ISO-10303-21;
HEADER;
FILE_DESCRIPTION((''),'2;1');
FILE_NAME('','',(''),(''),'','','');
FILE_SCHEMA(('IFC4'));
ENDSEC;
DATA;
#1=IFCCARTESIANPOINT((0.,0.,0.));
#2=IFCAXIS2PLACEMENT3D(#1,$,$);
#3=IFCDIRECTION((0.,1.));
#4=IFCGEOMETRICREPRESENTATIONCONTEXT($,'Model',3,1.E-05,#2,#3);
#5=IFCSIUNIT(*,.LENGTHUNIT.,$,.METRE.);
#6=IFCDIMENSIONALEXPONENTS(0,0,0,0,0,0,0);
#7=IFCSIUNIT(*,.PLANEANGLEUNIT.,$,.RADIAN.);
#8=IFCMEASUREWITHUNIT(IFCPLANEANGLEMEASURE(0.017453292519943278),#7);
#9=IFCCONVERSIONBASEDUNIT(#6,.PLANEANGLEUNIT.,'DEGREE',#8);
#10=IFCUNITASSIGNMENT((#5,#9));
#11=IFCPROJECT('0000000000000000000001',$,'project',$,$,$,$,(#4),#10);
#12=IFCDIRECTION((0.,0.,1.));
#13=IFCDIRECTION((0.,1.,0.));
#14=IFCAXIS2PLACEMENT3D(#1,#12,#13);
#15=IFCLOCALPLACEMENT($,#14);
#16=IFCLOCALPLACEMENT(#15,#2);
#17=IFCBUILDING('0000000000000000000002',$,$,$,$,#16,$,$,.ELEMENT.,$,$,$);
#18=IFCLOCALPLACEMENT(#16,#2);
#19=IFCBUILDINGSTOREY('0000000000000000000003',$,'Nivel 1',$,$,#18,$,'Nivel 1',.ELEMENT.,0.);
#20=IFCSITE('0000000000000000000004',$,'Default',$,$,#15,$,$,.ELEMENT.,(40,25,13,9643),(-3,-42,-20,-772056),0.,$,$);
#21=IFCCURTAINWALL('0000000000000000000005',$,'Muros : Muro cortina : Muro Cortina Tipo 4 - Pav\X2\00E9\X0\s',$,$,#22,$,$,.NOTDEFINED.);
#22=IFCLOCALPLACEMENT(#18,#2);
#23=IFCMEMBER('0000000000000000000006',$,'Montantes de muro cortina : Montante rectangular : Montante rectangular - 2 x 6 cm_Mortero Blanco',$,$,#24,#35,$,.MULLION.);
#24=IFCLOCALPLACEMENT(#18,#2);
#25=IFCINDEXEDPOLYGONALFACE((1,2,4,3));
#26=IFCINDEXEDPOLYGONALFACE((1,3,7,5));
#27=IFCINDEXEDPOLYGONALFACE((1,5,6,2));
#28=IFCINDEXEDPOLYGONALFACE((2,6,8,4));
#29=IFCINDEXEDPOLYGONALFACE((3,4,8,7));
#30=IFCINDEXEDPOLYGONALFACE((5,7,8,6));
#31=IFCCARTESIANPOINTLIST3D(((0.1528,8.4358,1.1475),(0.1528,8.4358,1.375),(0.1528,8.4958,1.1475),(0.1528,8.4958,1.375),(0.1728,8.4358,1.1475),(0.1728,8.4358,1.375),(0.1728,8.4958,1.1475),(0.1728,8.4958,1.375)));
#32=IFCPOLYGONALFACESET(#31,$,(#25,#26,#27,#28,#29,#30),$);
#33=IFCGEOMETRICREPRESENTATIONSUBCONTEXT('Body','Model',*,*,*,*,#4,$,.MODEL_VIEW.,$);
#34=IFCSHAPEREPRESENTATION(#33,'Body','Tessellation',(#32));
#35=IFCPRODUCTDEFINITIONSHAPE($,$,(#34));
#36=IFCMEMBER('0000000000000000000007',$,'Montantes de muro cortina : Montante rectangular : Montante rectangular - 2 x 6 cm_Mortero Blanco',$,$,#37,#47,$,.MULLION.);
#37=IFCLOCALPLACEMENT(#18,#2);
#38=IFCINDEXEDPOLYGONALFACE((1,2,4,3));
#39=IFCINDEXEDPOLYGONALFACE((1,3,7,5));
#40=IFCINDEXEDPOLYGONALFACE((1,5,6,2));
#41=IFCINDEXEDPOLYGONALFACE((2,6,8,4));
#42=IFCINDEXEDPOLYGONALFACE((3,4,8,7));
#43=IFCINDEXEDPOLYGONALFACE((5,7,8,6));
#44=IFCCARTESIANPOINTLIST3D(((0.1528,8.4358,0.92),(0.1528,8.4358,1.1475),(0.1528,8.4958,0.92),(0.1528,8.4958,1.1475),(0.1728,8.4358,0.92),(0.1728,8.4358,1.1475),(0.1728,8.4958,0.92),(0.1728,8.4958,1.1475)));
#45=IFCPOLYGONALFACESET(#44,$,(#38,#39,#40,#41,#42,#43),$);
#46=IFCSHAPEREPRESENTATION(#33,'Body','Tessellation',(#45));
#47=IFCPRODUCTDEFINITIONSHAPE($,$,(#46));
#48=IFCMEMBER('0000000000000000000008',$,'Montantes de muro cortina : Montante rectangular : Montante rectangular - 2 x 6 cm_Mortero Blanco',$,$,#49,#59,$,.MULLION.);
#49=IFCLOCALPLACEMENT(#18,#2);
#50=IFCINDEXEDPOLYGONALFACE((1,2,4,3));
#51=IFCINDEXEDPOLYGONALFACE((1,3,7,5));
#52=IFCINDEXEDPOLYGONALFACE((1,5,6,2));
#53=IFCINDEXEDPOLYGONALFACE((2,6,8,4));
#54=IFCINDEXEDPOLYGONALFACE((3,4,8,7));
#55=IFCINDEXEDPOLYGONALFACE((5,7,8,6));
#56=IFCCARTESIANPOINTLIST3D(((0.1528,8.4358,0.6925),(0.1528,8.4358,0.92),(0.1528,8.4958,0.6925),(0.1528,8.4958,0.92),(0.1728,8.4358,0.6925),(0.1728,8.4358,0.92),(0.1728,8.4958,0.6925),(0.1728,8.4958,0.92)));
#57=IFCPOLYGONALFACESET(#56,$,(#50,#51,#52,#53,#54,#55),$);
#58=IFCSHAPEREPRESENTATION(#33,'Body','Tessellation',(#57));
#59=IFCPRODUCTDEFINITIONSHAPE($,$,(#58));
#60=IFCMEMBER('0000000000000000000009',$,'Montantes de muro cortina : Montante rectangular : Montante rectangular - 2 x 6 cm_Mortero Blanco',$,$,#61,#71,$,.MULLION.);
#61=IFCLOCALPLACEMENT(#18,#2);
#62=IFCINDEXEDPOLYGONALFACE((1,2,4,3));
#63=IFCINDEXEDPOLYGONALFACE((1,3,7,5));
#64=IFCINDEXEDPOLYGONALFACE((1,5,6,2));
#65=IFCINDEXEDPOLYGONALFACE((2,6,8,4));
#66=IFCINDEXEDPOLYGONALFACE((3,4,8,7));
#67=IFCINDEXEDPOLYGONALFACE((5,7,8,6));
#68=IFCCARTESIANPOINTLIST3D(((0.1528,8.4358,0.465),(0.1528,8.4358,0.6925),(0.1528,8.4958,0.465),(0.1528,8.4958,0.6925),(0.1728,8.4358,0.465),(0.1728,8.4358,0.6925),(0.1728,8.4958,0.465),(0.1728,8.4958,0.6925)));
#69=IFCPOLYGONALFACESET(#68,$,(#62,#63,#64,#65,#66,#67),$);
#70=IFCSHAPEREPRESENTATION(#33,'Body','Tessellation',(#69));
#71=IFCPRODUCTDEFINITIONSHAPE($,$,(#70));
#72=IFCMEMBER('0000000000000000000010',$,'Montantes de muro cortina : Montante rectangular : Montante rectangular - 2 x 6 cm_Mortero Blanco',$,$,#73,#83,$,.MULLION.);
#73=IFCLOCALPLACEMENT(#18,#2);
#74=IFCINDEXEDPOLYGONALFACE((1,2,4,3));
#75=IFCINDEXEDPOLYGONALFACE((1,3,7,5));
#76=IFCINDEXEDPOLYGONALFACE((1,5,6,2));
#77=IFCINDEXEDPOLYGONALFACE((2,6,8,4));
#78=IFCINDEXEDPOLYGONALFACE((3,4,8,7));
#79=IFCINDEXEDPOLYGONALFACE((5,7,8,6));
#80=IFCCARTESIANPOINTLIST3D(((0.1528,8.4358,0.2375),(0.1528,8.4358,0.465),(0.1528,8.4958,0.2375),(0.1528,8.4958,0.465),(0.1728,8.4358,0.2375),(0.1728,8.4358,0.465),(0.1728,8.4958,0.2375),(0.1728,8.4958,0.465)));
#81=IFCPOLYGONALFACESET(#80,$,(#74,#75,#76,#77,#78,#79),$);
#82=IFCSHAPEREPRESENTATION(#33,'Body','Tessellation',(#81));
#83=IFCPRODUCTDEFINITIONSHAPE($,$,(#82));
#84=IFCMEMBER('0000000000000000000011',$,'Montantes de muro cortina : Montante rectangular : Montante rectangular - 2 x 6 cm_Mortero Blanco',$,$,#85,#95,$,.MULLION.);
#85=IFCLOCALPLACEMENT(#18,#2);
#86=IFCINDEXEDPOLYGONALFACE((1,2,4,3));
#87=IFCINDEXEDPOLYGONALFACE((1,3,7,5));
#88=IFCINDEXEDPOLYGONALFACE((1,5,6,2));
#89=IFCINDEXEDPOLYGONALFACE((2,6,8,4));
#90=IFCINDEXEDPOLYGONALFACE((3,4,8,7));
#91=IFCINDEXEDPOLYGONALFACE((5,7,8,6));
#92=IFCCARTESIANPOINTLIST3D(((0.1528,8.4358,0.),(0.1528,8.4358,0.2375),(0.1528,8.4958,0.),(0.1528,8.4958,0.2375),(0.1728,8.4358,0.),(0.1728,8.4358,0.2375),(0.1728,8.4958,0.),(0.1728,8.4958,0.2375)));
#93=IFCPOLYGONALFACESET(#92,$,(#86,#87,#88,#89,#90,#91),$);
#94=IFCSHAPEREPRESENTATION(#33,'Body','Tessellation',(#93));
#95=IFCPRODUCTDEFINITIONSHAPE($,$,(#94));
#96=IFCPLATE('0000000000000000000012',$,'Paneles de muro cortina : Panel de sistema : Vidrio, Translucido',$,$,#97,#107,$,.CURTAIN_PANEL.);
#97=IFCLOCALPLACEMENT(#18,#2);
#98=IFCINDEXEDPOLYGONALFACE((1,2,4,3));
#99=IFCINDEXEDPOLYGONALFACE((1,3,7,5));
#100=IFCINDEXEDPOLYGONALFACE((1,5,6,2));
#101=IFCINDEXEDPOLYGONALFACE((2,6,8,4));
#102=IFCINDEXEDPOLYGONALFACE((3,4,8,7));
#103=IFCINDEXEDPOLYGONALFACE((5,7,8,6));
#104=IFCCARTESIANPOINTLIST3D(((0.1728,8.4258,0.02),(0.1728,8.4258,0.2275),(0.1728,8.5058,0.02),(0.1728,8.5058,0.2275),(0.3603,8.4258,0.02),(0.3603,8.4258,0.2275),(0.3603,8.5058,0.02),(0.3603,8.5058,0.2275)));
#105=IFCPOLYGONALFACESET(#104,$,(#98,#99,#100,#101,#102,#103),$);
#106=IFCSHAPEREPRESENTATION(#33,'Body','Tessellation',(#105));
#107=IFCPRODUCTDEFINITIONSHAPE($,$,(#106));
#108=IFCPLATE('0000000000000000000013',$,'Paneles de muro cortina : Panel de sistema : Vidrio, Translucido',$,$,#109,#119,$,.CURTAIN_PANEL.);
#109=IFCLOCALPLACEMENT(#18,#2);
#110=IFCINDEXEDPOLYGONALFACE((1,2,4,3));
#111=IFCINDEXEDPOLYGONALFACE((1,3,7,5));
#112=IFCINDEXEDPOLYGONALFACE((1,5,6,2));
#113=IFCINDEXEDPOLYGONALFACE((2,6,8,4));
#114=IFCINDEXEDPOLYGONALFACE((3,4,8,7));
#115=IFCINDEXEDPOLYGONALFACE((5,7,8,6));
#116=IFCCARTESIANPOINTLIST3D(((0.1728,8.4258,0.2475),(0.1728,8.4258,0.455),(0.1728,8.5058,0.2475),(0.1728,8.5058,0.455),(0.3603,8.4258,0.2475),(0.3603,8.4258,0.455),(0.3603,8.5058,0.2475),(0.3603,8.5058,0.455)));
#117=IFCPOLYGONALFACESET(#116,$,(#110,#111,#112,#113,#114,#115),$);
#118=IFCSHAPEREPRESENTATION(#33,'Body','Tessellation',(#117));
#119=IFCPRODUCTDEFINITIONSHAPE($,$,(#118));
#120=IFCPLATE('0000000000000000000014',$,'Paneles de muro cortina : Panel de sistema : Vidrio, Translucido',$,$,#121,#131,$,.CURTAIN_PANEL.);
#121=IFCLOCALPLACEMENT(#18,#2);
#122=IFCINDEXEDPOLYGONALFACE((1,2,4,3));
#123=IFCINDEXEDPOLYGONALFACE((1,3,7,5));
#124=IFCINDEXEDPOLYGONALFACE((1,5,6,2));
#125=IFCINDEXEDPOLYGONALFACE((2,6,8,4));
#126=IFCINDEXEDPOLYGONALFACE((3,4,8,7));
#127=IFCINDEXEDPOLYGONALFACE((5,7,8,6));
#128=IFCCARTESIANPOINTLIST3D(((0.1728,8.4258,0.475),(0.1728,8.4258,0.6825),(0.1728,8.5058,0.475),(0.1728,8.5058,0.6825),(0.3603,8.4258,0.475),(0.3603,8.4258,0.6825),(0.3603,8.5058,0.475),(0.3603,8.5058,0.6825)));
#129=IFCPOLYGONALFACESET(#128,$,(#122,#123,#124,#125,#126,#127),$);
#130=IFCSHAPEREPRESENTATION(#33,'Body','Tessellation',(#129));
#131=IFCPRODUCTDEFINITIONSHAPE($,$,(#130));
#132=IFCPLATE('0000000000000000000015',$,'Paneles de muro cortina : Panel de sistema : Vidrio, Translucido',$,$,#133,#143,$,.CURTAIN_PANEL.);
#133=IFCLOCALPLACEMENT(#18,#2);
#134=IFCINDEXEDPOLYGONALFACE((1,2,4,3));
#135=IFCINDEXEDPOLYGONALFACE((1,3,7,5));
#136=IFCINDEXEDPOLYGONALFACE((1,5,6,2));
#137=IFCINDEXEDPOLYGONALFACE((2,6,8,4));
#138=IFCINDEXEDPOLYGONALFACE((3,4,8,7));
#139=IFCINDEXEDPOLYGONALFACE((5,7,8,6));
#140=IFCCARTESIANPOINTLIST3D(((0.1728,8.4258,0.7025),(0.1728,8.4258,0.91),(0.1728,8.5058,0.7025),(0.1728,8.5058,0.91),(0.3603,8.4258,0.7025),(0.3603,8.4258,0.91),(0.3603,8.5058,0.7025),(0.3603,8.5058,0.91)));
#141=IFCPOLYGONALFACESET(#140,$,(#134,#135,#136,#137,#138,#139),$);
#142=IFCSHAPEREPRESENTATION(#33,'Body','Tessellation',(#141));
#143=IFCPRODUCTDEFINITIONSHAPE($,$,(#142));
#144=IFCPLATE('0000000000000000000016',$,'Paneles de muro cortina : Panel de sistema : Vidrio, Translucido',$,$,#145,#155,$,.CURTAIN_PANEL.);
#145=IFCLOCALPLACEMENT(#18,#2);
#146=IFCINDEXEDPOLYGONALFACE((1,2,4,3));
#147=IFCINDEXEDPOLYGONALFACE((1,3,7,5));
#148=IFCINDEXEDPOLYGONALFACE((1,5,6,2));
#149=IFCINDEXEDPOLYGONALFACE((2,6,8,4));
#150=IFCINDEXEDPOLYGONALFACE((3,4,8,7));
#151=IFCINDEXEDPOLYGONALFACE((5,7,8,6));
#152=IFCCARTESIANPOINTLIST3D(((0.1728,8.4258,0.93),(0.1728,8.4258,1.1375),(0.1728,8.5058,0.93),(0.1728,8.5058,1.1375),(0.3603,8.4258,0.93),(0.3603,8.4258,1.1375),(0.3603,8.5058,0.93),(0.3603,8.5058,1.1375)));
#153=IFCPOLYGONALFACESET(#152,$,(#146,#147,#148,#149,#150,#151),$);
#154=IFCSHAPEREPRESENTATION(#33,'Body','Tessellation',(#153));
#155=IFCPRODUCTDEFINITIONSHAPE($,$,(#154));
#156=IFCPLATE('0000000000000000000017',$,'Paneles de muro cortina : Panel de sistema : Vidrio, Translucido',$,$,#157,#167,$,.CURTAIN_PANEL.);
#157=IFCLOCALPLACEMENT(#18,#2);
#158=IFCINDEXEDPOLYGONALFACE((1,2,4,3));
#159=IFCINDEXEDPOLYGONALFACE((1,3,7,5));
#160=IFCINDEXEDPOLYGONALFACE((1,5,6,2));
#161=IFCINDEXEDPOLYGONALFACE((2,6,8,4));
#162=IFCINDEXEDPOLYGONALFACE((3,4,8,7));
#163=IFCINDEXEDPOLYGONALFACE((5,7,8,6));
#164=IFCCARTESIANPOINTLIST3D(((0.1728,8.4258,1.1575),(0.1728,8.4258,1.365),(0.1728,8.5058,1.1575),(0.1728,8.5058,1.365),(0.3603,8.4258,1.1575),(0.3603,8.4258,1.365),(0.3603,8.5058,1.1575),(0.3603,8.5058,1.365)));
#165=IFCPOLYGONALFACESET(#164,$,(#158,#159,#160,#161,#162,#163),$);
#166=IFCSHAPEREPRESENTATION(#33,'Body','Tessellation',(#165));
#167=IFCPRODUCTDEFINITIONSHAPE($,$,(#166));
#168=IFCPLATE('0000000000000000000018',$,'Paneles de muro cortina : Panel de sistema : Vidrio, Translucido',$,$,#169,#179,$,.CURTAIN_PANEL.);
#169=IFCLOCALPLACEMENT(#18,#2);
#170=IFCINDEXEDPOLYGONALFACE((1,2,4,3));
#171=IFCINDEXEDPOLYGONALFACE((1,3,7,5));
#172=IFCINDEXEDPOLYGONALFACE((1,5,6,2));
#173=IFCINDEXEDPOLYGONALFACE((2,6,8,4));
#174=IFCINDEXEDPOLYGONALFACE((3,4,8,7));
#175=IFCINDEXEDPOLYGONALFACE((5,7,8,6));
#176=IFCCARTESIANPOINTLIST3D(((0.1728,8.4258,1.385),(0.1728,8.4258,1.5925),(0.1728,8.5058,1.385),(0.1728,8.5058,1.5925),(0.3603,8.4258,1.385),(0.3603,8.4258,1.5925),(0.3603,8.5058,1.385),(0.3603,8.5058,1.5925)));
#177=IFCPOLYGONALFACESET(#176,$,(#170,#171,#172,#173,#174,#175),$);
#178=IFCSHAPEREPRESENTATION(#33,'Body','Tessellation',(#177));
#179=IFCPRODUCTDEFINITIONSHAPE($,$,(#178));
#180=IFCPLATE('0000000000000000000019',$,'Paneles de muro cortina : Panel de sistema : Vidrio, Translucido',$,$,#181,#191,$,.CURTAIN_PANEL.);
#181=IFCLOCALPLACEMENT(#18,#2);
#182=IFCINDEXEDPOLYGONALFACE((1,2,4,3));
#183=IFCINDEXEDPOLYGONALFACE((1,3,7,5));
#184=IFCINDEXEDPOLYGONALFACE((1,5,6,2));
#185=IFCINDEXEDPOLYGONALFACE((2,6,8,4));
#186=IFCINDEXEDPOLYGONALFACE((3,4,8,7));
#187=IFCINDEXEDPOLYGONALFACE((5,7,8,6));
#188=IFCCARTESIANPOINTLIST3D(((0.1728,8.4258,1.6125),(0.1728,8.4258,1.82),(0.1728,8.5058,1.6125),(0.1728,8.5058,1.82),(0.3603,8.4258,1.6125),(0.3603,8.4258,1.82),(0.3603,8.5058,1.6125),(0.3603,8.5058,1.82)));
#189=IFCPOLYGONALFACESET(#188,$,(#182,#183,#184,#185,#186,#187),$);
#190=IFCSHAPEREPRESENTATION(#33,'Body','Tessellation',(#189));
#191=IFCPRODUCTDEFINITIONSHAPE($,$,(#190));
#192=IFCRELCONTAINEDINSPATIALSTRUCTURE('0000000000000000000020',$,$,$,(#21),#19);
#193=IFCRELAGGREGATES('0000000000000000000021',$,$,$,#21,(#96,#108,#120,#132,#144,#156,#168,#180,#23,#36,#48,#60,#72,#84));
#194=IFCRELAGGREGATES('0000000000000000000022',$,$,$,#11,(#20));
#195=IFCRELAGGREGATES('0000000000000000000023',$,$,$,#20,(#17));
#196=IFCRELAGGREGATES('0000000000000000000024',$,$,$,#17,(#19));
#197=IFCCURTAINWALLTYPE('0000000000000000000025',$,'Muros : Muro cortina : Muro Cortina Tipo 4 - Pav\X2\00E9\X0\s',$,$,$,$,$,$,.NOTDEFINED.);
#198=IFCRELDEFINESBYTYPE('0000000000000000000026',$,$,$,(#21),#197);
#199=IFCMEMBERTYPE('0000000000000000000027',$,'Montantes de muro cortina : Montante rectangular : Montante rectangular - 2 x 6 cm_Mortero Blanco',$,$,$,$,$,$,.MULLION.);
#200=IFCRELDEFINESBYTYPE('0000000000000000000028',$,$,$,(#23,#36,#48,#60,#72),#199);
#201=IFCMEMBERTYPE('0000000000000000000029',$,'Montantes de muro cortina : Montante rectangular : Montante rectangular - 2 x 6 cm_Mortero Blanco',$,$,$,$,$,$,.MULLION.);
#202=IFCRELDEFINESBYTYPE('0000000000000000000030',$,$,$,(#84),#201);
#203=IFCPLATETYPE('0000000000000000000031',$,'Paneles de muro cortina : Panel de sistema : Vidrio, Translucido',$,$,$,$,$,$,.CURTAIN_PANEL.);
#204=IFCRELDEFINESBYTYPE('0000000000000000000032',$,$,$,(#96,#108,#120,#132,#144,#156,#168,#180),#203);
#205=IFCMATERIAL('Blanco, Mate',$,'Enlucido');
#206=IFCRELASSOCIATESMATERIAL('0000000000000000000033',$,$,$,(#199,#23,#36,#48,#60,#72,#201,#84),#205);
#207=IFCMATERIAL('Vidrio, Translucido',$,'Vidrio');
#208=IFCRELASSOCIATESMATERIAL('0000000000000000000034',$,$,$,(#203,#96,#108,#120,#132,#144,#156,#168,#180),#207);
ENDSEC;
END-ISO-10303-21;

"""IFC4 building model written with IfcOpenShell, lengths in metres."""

from ifc_helpers import new_model, entity, si_unit, converted_unit, direction, frame, origin, place, context, subcontext, project, spatial, indexed_curve, outline, extrude, source, transform, mapped, material, type_object, type_shapes, element, aggregate, save


model = new_model("IFC4")

# Units and contexts
model_context = context("Model", 3, precision=1e-05, world=origin(), true_north=direction((0.0, 1.0)))
body_context = subcontext(model_context, "Body", "Model", "MODEL_VIEW")
ifc_project = project(units=[si_unit("LENGTHUNIT", "METRE"), converted_unit("PLANEANGLEUNIT", "DEGREE", entity("IfcPlaneAngleMeasure", 0.017453292519943278), si_unit("PLANEANGLEUNIT", "RADIAN"), dimensions=[0, 0, 0, 0, 0, 0, 0])], contexts=[model_context])

# Site, building, storey
site_placement = place(None, frame((0.0, 0.0, 0.0), z_axis=(0.0, 0.0, 1.0), x_axis=(0.0, 1.0, 0.0)))
site = spatial("IfcSite", under=ifc_project, at=site_placement, Name="Default", CompositionType="ELEMENT", RefLatitude=(40, 25, 13, 9643), RefLongitude=(-3, -42, -20, -772056), RefElevation=0.0)
building_placement = place(site_placement, origin())
building = spatial("IfcBuilding", under=site, at=building_placement, CompositionType="ELEMENT")
storey_placement = place(building_placement, origin())
storey = spatial("IfcBuildingStorey", under=building, at=storey_placement, Name="Nivel 1", LongName="Nivel 1", CompositionType="ELEMENT", Elevation=0.0)

# Curtain wall, members, plates
curtain_wall_type = type_object("IfcCurtainWallType", Name="Muros : Muro cortina : Muro Cortina Tipo 4 - Pavés", PredefinedType="NOTDEFINED")
curtain_wall_placement = place(storey_placement, origin())
curtain_wall = element("IfcCurtainWall", 1, at=curtain_wall_placement, inside=storey, type_object=curtain_wall_type, Name="Muros : Muro cortina : Muro Cortina Tipo 4 - Pavés", PredefinedType="NOTDEFINED")
ifc_material_1 = material(Name="Blanco, Mate", Category="Enlucido")
member_type_1 = type_object("IfcMemberType", Name="Montantes de muro cortina : Montante rectangular : Montante rectangular - 2 x 6 cm_Mortero Blanco", PredefinedType="MULLION", material=ifc_material_1)
shared_shape_1 = source(origin(), body_context, "Body", "SweptSolid", [
    extrude(outline(indexed_curve([(-0.01, -0.03), (0.01, -0.03), (0.01, 0.03), (-0.01, 0.03), (-0.01, -0.03)], self_intersect=False)), frame((-0.01, 0.0, -0.2275), z_axis=(0.0, 0.0, 1.0), x_axis=(-1.0, 0.0, 0.0)), (0.0, 0.0, 1.0), 0.2275),
])
type_shapes(member_type_1, [shared_shape_1])
member_1_placement = place(curtain_wall_placement, frame((0.1528, 8.4658, 1.1475), z_axis=(0.0, 0.0, -1.0), x_axis=(-1.0, 0.0, 0.0)))
member_1 = element("IfcMember", 2, at=member_1_placement, type_object=member_type_1, material=ifc_material_1, Name="Montantes de muro cortina : Montante rectangular : Montante rectangular - 2 x 6 cm_Mortero Blanco", PredefinedType="MULLION", context=body_context, shape_type="MappedRepresentation", body=[
    mapped(shared_shape_1, transform((0.0, 0.0, 0.0), scale=1.0)),
])
member_2_placement = place(curtain_wall_placement, frame((0.1528, 8.4658, 0.92), z_axis=(0.0, 0.0, -1.0), x_axis=(-1.0, 0.0, 0.0)))
member_2 = element("IfcMember", 3, at=member_2_placement, type_object=member_type_1, material=ifc_material_1, Name="Montantes de muro cortina : Montante rectangular : Montante rectangular - 2 x 6 cm_Mortero Blanco", PredefinedType="MULLION", context=body_context, shape_type="MappedRepresentation", body=[
    mapped(shared_shape_1, transform((0.0, 0.0, 0.0), scale=1.0)),
])
member_3_placement = place(curtain_wall_placement, frame((0.1528, 8.4658, 0.6925), z_axis=(0.0, 0.0, -1.0), x_axis=(-1.0, 0.0, 0.0)))
member_3 = element("IfcMember", 4, at=member_3_placement, type_object=member_type_1, material=ifc_material_1, Name="Montantes de muro cortina : Montante rectangular : Montante rectangular - 2 x 6 cm_Mortero Blanco", PredefinedType="MULLION", context=body_context, shape_type="MappedRepresentation", body=[
    mapped(shared_shape_1, transform((0.0, 0.0, 0.0), scale=1.0)),
])
member_4_placement = place(curtain_wall_placement, frame((0.1528, 8.4658, 0.465), z_axis=(0.0, 0.0, -1.0), x_axis=(-1.0, 0.0, 0.0)))
member_4 = element("IfcMember", 5, at=member_4_placement, type_object=member_type_1, material=ifc_material_1, Name="Montantes de muro cortina : Montante rectangular : Montante rectangular - 2 x 6 cm_Mortero Blanco", PredefinedType="MULLION", context=body_context, shape_type="MappedRepresentation", body=[
    mapped(shared_shape_1, transform((0.0, 0.0, 0.0), scale=1.0)),
])
member_5_placement = place(curtain_wall_placement, frame((0.1528, 8.4658, 0.2375), z_axis=(0.0, 0.0, -1.0), x_axis=(-1.0, 0.0, 0.0)))
member_5 = element("IfcMember", 6, at=member_5_placement, type_object=member_type_1, material=ifc_material_1, Name="Montantes de muro cortina : Montante rectangular : Montante rectangular - 2 x 6 cm_Mortero Blanco", PredefinedType="MULLION", context=body_context, shape_type="MappedRepresentation", body=[
    mapped(shared_shape_1, transform((0.0, 0.0, 0.0), scale=1.0)),
])
member_type_2 = type_object("IfcMemberType", Name="Montantes de muro cortina : Montante rectangular : Montante rectangular - 2 x 6 cm_Mortero Blanco", PredefinedType="MULLION", material=ifc_material_1)
shared_shape_2 = source(origin(), body_context, "Body", "SweptSolid", [
    extrude(outline(indexed_curve([(-0.01, -0.03), (0.01, -0.03), (0.01, 0.03), (-0.01, 0.03), (-0.01, -0.03)], self_intersect=False)), frame((-0.01, 0.0, -0.2375), z_axis=(0.0, 0.0, 1.0), x_axis=(-1.0, 0.0, 0.0)), (0.0, 0.0, 1.0), 0.2375),
])
type_shapes(member_type_2, [shared_shape_2])
member_6_placement = place(curtain_wall_placement, frame((0.1528, 8.4658, 0.0), z_axis=(0.0, 0.0, -1.0), x_axis=(-1.0, 0.0, 0.0)))
member_6 = element("IfcMember", 7, at=member_6_placement, type_object=member_type_2, material=ifc_material_1, Name="Montantes de muro cortina : Montante rectangular : Montante rectangular - 2 x 6 cm_Mortero Blanco", PredefinedType="MULLION", context=body_context, shape_type="MappedRepresentation", body=[
    mapped(shared_shape_2, transform((0.0, 0.0, 0.0), scale=1.0)),
])
ifc_material_2 = material(Name="Vidrio, Translucido", Category="Vidrio")
plate_type = type_object("IfcPlateType", Name="Paneles de muro cortina : Panel de sistema : Vidrio, Translucido", PredefinedType="CURTAIN_PANEL", material=ifc_material_2)
shared_shape_3 = source(origin(), body_context, "Body", "SweptSolid", [
    extrude(outline(indexed_curve([(-0.04, -0.0938), (0.04, -0.0938), (0.04, 0.0938), (-0.04, 0.0938), (-0.04, -0.0938)], self_intersect=False)), frame((0.0, 0.0, 0.0), z_axis=(0.0, 0.0, 1.0), x_axis=(0.0, 1.0, 0.0)), (0.0, 0.0, 1.0), 0.2075),
])
type_shapes(plate_type, [shared_shape_3])
plate_1_placement = place(curtain_wall_placement, frame((0.2665, 8.4658, 0.02), z_axis=(0.0, 0.0, 1.0), x_axis=(-1.0, 0.0, 0.0)))
plate_1 = element("IfcPlate", 8, at=plate_1_placement, type_object=plate_type, material=ifc_material_2, Name="Paneles de muro cortina : Panel de sistema : Vidrio, Translucido", PredefinedType="CURTAIN_PANEL", context=body_context, shape_type="MappedRepresentation", body=[
    mapped(shared_shape_3, transform((0.0, 0.0, 0.0), scale=1.0)),
])
plate_2_placement = place(curtain_wall_placement, frame((0.2665, 8.4658, 0.2475), z_axis=(0.0, 0.0, 1.0), x_axis=(-1.0, 0.0, 0.0)))
plate_2 = element("IfcPlate", 9, at=plate_2_placement, type_object=plate_type, material=ifc_material_2, Name="Paneles de muro cortina : Panel de sistema : Vidrio, Translucido", PredefinedType="CURTAIN_PANEL", context=body_context, shape_type="MappedRepresentation", body=[
    mapped(shared_shape_3, transform((0.0, 0.0, 0.0), scale=1.0)),
])
plate_3_placement = place(curtain_wall_placement, frame((0.2665, 8.4658, 0.475), z_axis=(0.0, 0.0, 1.0), x_axis=(-1.0, 0.0, 0.0)))
plate_3 = element("IfcPlate", 10, at=plate_3_placement, type_object=plate_type, material=ifc_material_2, Name="Paneles de muro cortina : Panel de sistema : Vidrio, Translucido", PredefinedType="CURTAIN_PANEL", context=body_context, shape_type="MappedRepresentation", body=[
    mapped(shared_shape_3, transform((0.0, 0.0, 0.0), scale=1.0)),
])
plate_4_placement = place(curtain_wall_placement, frame((0.2665, 8.4658, 0.7025), z_axis=(0.0, 0.0, 1.0), x_axis=(-1.0, 0.0, 0.0)))
plate_4 = element("IfcPlate", 11, at=plate_4_placement, type_object=plate_type, material=ifc_material_2, Name="Paneles de muro cortina : Panel de sistema : Vidrio, Translucido", PredefinedType="CURTAIN_PANEL", context=body_context, shape_type="MappedRepresentation", body=[
    mapped(shared_shape_3, transform((0.0, 0.0, 0.0), scale=1.0)),
])
plate_5_placement = place(curtain_wall_placement, frame((0.2665, 8.4658, 0.93), z_axis=(0.0, 0.0, 1.0), x_axis=(-1.0, 0.0, 0.0)))
plate_5 = element("IfcPlate", 12, at=plate_5_placement, type_object=plate_type, material=ifc_material_2, Name="Paneles de muro cortina : Panel de sistema : Vidrio, Translucido", PredefinedType="CURTAIN_PANEL", context=body_context, shape_type="MappedRepresentation", body=[
    mapped(shared_shape_3, transform((0.0, 0.0, 0.0), scale=1.0)),
])
plate_6_placement = place(curtain_wall_placement, frame((0.2665, 8.4658, 1.1575), z_axis=(0.0, 0.0, 1.0), x_axis=(-1.0, 0.0, 0.0)))
plate_6 = element("IfcPlate", 13, at=plate_6_placement, type_object=plate_type, material=ifc_material_2, Name="Paneles de muro cortina : Panel de sistema : Vidrio, Translucido", PredefinedType="CURTAIN_PANEL", context=body_context, shape_type="MappedRepresentation", body=[
    mapped(shared_shape_3, transform((0.0, 0.0, 0.0), scale=1.0)),
])
plate_7_placement = place(curtain_wall_placement, frame((0.2665, 8.4658, 1.385), z_axis=(0.0, 0.0, 1.0), x_axis=(-1.0, 0.0, 0.0)))
plate_7 = element("IfcPlate", 14, at=plate_7_placement, type_object=plate_type, material=ifc_material_2, Name="Paneles de muro cortina : Panel de sistema : Vidrio, Translucido", PredefinedType="CURTAIN_PANEL", context=body_context, shape_type="MappedRepresentation", body=[
    mapped(shared_shape_3, transform((0.0, 0.0, 0.0), scale=1.0)),
])
plate_8_placement = place(curtain_wall_placement, frame((0.2665, 8.4658, 1.6125), z_axis=(0.0, 0.0, 1.0), x_axis=(-1.0, 0.0, 0.0)))
plate_8 = element("IfcPlate", 15, at=plate_8_placement, type_object=plate_type, material=ifc_material_2, Name="Paneles de muro cortina : Panel de sistema : Vidrio, Translucido", PredefinedType="CURTAIN_PANEL", context=body_context, shape_type="MappedRepresentation", body=[
    mapped(shared_shape_3, transform((0.0, 0.0, 0.0), scale=1.0)),
])
aggregate(curtain_wall, [plate_1, plate_2, plate_3, plate_4, plate_5, plate_6, plate_7, plate_8, member_1, member_2, member_3, member_4, member_5, member_6])

save(model, "model.ifc")
